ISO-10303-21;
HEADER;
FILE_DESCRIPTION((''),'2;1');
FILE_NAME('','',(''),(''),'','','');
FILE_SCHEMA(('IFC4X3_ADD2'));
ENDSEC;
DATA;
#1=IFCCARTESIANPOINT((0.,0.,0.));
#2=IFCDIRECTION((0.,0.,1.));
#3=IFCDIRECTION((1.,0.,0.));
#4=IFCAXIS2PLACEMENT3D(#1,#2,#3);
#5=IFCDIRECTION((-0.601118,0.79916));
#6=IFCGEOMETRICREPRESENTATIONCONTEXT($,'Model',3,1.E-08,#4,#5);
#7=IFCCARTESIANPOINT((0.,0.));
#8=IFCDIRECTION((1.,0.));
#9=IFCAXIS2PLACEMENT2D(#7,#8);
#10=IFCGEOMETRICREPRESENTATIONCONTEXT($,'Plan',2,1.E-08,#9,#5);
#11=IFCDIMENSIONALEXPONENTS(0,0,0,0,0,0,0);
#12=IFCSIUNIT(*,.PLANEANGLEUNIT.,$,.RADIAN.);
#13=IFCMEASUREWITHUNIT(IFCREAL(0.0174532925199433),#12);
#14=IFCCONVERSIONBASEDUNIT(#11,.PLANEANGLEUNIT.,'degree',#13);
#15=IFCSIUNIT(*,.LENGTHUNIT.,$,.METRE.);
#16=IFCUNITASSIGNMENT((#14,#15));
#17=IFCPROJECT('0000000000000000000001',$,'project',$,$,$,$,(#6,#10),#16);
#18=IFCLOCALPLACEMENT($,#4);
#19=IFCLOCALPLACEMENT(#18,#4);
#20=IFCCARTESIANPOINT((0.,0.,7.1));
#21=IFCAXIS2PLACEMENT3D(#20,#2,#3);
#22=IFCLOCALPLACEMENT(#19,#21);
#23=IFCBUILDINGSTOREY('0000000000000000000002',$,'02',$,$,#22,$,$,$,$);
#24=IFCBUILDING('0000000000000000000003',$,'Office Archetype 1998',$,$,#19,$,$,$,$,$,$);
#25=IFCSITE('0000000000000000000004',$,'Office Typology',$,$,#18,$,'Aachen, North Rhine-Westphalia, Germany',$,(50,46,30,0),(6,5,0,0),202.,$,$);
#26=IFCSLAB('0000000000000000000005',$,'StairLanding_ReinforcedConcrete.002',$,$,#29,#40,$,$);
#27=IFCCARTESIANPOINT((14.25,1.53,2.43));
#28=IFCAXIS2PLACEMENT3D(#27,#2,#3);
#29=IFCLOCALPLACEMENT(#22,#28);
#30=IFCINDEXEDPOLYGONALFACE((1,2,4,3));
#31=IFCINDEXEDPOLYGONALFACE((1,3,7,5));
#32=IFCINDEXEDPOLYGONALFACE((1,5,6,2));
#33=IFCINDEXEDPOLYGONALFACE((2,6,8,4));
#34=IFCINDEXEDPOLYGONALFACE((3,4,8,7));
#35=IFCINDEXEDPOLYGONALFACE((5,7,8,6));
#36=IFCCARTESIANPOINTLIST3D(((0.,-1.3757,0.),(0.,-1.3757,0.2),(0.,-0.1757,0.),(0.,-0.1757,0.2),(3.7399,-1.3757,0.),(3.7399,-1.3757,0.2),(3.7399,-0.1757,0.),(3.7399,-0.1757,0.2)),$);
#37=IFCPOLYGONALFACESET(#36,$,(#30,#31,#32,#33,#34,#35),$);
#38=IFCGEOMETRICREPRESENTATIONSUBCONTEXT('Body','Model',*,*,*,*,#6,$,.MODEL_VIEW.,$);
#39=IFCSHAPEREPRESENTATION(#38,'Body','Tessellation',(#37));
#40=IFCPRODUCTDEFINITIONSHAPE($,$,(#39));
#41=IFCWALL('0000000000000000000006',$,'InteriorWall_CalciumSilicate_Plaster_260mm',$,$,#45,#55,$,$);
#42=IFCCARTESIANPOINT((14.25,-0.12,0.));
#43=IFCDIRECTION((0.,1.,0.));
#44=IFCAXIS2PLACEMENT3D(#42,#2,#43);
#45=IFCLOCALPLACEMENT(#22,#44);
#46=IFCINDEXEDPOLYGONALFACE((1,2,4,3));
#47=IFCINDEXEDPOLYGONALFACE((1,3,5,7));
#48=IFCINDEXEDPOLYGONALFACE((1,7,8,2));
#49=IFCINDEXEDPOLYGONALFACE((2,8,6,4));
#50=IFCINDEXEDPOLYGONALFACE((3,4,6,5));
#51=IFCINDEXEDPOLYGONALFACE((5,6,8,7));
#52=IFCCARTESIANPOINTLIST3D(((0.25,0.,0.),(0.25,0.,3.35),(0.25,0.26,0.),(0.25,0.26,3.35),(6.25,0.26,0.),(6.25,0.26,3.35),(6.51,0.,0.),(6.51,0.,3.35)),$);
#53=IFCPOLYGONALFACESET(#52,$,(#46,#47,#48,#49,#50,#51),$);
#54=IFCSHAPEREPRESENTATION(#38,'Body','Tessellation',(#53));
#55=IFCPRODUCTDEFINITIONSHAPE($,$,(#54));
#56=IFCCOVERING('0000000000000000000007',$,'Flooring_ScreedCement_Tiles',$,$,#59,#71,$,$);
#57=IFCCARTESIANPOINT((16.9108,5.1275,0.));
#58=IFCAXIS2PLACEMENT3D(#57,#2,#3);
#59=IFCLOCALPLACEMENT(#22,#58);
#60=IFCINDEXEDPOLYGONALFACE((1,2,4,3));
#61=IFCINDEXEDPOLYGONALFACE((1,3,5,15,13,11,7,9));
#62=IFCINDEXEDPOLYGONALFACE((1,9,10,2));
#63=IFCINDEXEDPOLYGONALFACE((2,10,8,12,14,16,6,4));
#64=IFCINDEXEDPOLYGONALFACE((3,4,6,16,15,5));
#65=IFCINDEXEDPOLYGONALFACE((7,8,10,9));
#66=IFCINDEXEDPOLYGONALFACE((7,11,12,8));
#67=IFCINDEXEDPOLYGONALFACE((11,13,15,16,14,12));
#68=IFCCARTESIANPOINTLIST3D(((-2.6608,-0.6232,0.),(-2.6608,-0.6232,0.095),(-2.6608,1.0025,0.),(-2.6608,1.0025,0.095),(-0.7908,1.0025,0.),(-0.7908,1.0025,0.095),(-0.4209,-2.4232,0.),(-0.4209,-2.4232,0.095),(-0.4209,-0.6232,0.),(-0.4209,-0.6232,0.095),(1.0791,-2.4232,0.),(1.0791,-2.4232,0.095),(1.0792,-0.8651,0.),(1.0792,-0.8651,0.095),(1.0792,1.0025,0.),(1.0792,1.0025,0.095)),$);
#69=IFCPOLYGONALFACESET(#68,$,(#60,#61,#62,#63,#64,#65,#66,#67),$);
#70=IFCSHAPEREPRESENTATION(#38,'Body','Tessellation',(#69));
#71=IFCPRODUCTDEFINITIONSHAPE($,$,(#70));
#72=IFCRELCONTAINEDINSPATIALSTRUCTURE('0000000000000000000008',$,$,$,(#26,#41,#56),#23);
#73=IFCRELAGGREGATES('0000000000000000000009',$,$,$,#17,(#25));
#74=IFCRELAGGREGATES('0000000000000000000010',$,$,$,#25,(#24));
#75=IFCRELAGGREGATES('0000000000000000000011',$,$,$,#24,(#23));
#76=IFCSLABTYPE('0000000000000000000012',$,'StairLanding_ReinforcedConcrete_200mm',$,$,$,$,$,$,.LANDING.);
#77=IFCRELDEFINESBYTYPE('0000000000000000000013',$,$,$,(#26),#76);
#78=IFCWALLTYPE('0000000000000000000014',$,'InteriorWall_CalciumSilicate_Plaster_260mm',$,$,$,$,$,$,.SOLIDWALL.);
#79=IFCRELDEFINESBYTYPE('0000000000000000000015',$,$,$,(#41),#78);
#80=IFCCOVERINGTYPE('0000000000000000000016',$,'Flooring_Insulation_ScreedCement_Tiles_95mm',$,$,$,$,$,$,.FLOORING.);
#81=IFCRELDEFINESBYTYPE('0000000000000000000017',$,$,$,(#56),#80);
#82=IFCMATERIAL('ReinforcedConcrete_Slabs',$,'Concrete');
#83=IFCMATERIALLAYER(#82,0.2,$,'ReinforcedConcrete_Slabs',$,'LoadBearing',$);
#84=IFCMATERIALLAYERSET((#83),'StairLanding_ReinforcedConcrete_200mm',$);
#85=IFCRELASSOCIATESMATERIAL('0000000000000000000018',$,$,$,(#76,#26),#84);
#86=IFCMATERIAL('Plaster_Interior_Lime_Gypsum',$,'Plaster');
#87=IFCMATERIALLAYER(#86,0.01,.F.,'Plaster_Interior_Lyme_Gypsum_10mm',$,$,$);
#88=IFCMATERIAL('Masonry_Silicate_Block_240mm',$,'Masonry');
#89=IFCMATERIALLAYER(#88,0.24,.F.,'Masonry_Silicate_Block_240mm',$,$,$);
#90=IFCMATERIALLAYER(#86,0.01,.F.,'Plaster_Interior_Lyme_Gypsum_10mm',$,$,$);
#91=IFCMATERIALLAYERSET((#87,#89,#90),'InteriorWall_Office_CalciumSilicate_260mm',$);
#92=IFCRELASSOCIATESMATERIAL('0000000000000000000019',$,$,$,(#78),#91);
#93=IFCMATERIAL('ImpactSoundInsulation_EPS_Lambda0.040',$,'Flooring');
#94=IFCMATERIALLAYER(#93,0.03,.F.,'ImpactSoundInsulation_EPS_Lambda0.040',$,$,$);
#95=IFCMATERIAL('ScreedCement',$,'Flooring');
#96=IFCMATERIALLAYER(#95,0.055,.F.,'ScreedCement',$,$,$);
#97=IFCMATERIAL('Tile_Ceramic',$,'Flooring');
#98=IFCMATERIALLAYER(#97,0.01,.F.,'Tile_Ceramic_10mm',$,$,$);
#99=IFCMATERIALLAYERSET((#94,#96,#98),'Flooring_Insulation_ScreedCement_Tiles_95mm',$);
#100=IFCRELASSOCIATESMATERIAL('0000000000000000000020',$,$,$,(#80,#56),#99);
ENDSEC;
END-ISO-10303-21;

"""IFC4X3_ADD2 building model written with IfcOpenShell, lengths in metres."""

from ifc_helpers import new_model, entity, si_unit, converted_unit, direction, frame, origin_with_axes, origin_2d_with_axis, place, context, subcontext, project, spatial, line, indexed_curve, outline, extrude, material, layer, layer_set, layer_usage, type_object, element, save


model = new_model("IFC4X3_ADD2")

# Units and contexts
model_context = context("Model", 3, precision=1e-08, world=origin_with_axes(), true_north=direction((-0.601118, 0.79916)))
plan_context = context("Plan", 2, precision=1e-08, world=origin_2d_with_axis(), true_north=direction((-0.601118, 0.79916)))
body_context = subcontext(model_context, "Body", "Model", "MODEL_VIEW")
ifc_project = project(units=[converted_unit("PLANEANGLEUNIT", "degree", entity("IfcReal", 0.0174532925199433), si_unit("PLANEANGLEUNIT", "RADIAN"), dimensions=[0, 0, 0, 0, 0, 0, 0]), si_unit("LENGTHUNIT", "METRE")], contexts=[model_context, plan_context])

# Site, building, storey
site_placement = place(None, origin_with_axes())
site = spatial("IfcSite", under=ifc_project, at=site_placement, Name="Office Typology", LongName="Aachen, North Rhine-Westphalia, Germany", RefLatitude=(50, 46, 30, 0), RefLongitude=(6, 5, 0, 0), RefElevation=202.0)
building_placement = place(site_placement, origin_with_axes())
building = spatial("IfcBuilding", under=site, at=building_placement, Name="Office Archetype 1998")
storey_placement = place(building_placement, frame((0.0, 0.0, 7.1), z_axis=(0.0, 0.0, 1.0), x_axis=(1.0, 0.0, 0.0)))
storey = spatial("IfcBuildingStorey", under=building, at=storey_placement, Name="02")

# Slab
ifc_material_1 = material(Name="ReinforcedConcrete_Slabs", Category="Concrete")
ifc_layer_1 = layer(ifc_material_1, 0.2, Name="ReinforcedConcrete_Slabs", Category="LoadBearing")
ifc_layer_set_1 = layer_set([ifc_layer_1], Name="StairLanding_ReinforcedConcrete_200mm")
ifc_layer_usage_1 = layer_usage(ifc_layer_set_1, "AXIS3", "POSITIVE", 0.0)
slab_type_1 = type_object("IfcSlabType", Name="StairLanding_ReinforcedConcrete_200mm", PredefinedType="LANDING", material=ifc_layer_set_1)
slab_1_placement = place(storey_placement, frame((14.25, 1.53, 2.43), z_axis=(0.0, 0.0, 1.0), x_axis=(1.0, 0.0, 0.0)))
element("IfcSlab", 1, at=slab_1_placement, inside=storey, type_object=slab_type_1, material=ifc_layer_usage_1, Name="StairLanding_ReinforcedConcrete.002", context=body_context, shape_type="SweptSolid", body=[
    extrude(outline(indexed_curve([(3.7399, -0.1757), (3.7399, -1.3757), (0.0, -1.3757), (0.0, -0.1757), (3.7399, -0.1757)])), None, (0.0, 0.0, 1.0), 0.2),
])

# Wall
ifc_material_2 = material(Name="Plaster_Interior_Lime_Gypsum", Category="Plaster")
ifc_layer_2 = layer(ifc_material_2, 0.01, ventilated=False, Name="Plaster_Interior_Lyme_Gypsum_10mm")
ifc_material_3 = material(Name="Masonry_Silicate_Block_240mm", Category="Masonry")
ifc_layer_3 = layer(ifc_material_3, 0.24, ventilated=False, Name="Masonry_Silicate_Block_240mm")
ifc_layer_4 = layer(ifc_material_2, 0.01, ventilated=False, Name="Plaster_Interior_Lyme_Gypsum_10mm")
ifc_layer_set_2 = layer_set([ifc_layer_2, ifc_layer_3, ifc_layer_4], Name="InteriorWall_Office_CalciumSilicate_260mm")
wall_type = type_object("IfcWallType", Name="InteriorWall_CalciumSilicate_Plaster_260mm", PredefinedType="SOLIDWALL", material=ifc_layer_set_2)
wall_placement = place(storey_placement, frame((14.25, -0.12, 0.0), z_axis=(0.0, 0.0, 1.0), x_axis=(0.0, 1.0, 0.0)))
element("IfcWall", 2, at=wall_placement, inside=storey, type_object=wall_type, Name="InteriorWall_CalciumSilicate_Plaster_260mm", context=body_context, shape_type="SweptSolid", body=[
    extrude(outline(indexed_curve([(0.25, 0.0), (0.25, 0.26), (6.25, 0.26), (6.51, 0.0)], segments=[line(1, 2, 3, 4, 1)])), origin_with_axes(), (0.0, 0.0, 1.0), 3.35),
])

# Covering
ifc_material_4 = material(Name="ImpactSoundInsulation_EPS_Lambda0.040", Category="Flooring")
ifc_layer_5 = layer(ifc_material_4, 0.03, ventilated=False, Name="ImpactSoundInsulation_EPS_Lambda0.040")
ifc_material_5 = material(Name="ScreedCement", Category="Flooring")
ifc_layer_6 = layer(ifc_material_5, 0.055, ventilated=False, Name="ScreedCement")
ifc_material_6 = material(Name="Tile_Ceramic", Category="Flooring")
ifc_layer_7 = layer(ifc_material_6, 0.01, ventilated=False, Name="Tile_Ceramic_10mm")
ifc_layer_set_3 = layer_set([ifc_layer_5, ifc_layer_6, ifc_layer_7], Name="Flooring_Insulation_ScreedCement_Tiles_95mm")
ifc_layer_usage_2 = layer_usage(ifc_layer_set_3, "AXIS3", "POSITIVE", 0.0)
covering_type = type_object("IfcCoveringType", Name="Flooring_Insulation_ScreedCement_Tiles_95mm", PredefinedType="FLOORING", material=ifc_layer_set_3)
covering_placement = place(storey_placement, frame((16.9108, 5.1275, 0.0), z_axis=(0.0, 0.0, 1.0), x_axis=(1.0, 0.0, 0.0)))
element("IfcCovering", 3, at=covering_placement, inside=storey, type_object=covering_type, material=ifc_layer_usage_2, Name="Flooring_ScreedCement_Tiles", context=body_context, shape_type="SweptSolid", body=[
    extrude(outline(indexed_curve([(-0.7908, 1.0025), (-2.6608, 1.0025), (-2.6608, -0.6232), (-0.4209, -0.6232), (-0.4209, -2.4232), (1.0791, -2.4232), (1.0792, -0.8651), (1.0792, 1.0025), (-0.7908, 1.0025)])), None, (0.0, 0.0, 1.0), 0.095),
])

save(model, "model.ifc")
